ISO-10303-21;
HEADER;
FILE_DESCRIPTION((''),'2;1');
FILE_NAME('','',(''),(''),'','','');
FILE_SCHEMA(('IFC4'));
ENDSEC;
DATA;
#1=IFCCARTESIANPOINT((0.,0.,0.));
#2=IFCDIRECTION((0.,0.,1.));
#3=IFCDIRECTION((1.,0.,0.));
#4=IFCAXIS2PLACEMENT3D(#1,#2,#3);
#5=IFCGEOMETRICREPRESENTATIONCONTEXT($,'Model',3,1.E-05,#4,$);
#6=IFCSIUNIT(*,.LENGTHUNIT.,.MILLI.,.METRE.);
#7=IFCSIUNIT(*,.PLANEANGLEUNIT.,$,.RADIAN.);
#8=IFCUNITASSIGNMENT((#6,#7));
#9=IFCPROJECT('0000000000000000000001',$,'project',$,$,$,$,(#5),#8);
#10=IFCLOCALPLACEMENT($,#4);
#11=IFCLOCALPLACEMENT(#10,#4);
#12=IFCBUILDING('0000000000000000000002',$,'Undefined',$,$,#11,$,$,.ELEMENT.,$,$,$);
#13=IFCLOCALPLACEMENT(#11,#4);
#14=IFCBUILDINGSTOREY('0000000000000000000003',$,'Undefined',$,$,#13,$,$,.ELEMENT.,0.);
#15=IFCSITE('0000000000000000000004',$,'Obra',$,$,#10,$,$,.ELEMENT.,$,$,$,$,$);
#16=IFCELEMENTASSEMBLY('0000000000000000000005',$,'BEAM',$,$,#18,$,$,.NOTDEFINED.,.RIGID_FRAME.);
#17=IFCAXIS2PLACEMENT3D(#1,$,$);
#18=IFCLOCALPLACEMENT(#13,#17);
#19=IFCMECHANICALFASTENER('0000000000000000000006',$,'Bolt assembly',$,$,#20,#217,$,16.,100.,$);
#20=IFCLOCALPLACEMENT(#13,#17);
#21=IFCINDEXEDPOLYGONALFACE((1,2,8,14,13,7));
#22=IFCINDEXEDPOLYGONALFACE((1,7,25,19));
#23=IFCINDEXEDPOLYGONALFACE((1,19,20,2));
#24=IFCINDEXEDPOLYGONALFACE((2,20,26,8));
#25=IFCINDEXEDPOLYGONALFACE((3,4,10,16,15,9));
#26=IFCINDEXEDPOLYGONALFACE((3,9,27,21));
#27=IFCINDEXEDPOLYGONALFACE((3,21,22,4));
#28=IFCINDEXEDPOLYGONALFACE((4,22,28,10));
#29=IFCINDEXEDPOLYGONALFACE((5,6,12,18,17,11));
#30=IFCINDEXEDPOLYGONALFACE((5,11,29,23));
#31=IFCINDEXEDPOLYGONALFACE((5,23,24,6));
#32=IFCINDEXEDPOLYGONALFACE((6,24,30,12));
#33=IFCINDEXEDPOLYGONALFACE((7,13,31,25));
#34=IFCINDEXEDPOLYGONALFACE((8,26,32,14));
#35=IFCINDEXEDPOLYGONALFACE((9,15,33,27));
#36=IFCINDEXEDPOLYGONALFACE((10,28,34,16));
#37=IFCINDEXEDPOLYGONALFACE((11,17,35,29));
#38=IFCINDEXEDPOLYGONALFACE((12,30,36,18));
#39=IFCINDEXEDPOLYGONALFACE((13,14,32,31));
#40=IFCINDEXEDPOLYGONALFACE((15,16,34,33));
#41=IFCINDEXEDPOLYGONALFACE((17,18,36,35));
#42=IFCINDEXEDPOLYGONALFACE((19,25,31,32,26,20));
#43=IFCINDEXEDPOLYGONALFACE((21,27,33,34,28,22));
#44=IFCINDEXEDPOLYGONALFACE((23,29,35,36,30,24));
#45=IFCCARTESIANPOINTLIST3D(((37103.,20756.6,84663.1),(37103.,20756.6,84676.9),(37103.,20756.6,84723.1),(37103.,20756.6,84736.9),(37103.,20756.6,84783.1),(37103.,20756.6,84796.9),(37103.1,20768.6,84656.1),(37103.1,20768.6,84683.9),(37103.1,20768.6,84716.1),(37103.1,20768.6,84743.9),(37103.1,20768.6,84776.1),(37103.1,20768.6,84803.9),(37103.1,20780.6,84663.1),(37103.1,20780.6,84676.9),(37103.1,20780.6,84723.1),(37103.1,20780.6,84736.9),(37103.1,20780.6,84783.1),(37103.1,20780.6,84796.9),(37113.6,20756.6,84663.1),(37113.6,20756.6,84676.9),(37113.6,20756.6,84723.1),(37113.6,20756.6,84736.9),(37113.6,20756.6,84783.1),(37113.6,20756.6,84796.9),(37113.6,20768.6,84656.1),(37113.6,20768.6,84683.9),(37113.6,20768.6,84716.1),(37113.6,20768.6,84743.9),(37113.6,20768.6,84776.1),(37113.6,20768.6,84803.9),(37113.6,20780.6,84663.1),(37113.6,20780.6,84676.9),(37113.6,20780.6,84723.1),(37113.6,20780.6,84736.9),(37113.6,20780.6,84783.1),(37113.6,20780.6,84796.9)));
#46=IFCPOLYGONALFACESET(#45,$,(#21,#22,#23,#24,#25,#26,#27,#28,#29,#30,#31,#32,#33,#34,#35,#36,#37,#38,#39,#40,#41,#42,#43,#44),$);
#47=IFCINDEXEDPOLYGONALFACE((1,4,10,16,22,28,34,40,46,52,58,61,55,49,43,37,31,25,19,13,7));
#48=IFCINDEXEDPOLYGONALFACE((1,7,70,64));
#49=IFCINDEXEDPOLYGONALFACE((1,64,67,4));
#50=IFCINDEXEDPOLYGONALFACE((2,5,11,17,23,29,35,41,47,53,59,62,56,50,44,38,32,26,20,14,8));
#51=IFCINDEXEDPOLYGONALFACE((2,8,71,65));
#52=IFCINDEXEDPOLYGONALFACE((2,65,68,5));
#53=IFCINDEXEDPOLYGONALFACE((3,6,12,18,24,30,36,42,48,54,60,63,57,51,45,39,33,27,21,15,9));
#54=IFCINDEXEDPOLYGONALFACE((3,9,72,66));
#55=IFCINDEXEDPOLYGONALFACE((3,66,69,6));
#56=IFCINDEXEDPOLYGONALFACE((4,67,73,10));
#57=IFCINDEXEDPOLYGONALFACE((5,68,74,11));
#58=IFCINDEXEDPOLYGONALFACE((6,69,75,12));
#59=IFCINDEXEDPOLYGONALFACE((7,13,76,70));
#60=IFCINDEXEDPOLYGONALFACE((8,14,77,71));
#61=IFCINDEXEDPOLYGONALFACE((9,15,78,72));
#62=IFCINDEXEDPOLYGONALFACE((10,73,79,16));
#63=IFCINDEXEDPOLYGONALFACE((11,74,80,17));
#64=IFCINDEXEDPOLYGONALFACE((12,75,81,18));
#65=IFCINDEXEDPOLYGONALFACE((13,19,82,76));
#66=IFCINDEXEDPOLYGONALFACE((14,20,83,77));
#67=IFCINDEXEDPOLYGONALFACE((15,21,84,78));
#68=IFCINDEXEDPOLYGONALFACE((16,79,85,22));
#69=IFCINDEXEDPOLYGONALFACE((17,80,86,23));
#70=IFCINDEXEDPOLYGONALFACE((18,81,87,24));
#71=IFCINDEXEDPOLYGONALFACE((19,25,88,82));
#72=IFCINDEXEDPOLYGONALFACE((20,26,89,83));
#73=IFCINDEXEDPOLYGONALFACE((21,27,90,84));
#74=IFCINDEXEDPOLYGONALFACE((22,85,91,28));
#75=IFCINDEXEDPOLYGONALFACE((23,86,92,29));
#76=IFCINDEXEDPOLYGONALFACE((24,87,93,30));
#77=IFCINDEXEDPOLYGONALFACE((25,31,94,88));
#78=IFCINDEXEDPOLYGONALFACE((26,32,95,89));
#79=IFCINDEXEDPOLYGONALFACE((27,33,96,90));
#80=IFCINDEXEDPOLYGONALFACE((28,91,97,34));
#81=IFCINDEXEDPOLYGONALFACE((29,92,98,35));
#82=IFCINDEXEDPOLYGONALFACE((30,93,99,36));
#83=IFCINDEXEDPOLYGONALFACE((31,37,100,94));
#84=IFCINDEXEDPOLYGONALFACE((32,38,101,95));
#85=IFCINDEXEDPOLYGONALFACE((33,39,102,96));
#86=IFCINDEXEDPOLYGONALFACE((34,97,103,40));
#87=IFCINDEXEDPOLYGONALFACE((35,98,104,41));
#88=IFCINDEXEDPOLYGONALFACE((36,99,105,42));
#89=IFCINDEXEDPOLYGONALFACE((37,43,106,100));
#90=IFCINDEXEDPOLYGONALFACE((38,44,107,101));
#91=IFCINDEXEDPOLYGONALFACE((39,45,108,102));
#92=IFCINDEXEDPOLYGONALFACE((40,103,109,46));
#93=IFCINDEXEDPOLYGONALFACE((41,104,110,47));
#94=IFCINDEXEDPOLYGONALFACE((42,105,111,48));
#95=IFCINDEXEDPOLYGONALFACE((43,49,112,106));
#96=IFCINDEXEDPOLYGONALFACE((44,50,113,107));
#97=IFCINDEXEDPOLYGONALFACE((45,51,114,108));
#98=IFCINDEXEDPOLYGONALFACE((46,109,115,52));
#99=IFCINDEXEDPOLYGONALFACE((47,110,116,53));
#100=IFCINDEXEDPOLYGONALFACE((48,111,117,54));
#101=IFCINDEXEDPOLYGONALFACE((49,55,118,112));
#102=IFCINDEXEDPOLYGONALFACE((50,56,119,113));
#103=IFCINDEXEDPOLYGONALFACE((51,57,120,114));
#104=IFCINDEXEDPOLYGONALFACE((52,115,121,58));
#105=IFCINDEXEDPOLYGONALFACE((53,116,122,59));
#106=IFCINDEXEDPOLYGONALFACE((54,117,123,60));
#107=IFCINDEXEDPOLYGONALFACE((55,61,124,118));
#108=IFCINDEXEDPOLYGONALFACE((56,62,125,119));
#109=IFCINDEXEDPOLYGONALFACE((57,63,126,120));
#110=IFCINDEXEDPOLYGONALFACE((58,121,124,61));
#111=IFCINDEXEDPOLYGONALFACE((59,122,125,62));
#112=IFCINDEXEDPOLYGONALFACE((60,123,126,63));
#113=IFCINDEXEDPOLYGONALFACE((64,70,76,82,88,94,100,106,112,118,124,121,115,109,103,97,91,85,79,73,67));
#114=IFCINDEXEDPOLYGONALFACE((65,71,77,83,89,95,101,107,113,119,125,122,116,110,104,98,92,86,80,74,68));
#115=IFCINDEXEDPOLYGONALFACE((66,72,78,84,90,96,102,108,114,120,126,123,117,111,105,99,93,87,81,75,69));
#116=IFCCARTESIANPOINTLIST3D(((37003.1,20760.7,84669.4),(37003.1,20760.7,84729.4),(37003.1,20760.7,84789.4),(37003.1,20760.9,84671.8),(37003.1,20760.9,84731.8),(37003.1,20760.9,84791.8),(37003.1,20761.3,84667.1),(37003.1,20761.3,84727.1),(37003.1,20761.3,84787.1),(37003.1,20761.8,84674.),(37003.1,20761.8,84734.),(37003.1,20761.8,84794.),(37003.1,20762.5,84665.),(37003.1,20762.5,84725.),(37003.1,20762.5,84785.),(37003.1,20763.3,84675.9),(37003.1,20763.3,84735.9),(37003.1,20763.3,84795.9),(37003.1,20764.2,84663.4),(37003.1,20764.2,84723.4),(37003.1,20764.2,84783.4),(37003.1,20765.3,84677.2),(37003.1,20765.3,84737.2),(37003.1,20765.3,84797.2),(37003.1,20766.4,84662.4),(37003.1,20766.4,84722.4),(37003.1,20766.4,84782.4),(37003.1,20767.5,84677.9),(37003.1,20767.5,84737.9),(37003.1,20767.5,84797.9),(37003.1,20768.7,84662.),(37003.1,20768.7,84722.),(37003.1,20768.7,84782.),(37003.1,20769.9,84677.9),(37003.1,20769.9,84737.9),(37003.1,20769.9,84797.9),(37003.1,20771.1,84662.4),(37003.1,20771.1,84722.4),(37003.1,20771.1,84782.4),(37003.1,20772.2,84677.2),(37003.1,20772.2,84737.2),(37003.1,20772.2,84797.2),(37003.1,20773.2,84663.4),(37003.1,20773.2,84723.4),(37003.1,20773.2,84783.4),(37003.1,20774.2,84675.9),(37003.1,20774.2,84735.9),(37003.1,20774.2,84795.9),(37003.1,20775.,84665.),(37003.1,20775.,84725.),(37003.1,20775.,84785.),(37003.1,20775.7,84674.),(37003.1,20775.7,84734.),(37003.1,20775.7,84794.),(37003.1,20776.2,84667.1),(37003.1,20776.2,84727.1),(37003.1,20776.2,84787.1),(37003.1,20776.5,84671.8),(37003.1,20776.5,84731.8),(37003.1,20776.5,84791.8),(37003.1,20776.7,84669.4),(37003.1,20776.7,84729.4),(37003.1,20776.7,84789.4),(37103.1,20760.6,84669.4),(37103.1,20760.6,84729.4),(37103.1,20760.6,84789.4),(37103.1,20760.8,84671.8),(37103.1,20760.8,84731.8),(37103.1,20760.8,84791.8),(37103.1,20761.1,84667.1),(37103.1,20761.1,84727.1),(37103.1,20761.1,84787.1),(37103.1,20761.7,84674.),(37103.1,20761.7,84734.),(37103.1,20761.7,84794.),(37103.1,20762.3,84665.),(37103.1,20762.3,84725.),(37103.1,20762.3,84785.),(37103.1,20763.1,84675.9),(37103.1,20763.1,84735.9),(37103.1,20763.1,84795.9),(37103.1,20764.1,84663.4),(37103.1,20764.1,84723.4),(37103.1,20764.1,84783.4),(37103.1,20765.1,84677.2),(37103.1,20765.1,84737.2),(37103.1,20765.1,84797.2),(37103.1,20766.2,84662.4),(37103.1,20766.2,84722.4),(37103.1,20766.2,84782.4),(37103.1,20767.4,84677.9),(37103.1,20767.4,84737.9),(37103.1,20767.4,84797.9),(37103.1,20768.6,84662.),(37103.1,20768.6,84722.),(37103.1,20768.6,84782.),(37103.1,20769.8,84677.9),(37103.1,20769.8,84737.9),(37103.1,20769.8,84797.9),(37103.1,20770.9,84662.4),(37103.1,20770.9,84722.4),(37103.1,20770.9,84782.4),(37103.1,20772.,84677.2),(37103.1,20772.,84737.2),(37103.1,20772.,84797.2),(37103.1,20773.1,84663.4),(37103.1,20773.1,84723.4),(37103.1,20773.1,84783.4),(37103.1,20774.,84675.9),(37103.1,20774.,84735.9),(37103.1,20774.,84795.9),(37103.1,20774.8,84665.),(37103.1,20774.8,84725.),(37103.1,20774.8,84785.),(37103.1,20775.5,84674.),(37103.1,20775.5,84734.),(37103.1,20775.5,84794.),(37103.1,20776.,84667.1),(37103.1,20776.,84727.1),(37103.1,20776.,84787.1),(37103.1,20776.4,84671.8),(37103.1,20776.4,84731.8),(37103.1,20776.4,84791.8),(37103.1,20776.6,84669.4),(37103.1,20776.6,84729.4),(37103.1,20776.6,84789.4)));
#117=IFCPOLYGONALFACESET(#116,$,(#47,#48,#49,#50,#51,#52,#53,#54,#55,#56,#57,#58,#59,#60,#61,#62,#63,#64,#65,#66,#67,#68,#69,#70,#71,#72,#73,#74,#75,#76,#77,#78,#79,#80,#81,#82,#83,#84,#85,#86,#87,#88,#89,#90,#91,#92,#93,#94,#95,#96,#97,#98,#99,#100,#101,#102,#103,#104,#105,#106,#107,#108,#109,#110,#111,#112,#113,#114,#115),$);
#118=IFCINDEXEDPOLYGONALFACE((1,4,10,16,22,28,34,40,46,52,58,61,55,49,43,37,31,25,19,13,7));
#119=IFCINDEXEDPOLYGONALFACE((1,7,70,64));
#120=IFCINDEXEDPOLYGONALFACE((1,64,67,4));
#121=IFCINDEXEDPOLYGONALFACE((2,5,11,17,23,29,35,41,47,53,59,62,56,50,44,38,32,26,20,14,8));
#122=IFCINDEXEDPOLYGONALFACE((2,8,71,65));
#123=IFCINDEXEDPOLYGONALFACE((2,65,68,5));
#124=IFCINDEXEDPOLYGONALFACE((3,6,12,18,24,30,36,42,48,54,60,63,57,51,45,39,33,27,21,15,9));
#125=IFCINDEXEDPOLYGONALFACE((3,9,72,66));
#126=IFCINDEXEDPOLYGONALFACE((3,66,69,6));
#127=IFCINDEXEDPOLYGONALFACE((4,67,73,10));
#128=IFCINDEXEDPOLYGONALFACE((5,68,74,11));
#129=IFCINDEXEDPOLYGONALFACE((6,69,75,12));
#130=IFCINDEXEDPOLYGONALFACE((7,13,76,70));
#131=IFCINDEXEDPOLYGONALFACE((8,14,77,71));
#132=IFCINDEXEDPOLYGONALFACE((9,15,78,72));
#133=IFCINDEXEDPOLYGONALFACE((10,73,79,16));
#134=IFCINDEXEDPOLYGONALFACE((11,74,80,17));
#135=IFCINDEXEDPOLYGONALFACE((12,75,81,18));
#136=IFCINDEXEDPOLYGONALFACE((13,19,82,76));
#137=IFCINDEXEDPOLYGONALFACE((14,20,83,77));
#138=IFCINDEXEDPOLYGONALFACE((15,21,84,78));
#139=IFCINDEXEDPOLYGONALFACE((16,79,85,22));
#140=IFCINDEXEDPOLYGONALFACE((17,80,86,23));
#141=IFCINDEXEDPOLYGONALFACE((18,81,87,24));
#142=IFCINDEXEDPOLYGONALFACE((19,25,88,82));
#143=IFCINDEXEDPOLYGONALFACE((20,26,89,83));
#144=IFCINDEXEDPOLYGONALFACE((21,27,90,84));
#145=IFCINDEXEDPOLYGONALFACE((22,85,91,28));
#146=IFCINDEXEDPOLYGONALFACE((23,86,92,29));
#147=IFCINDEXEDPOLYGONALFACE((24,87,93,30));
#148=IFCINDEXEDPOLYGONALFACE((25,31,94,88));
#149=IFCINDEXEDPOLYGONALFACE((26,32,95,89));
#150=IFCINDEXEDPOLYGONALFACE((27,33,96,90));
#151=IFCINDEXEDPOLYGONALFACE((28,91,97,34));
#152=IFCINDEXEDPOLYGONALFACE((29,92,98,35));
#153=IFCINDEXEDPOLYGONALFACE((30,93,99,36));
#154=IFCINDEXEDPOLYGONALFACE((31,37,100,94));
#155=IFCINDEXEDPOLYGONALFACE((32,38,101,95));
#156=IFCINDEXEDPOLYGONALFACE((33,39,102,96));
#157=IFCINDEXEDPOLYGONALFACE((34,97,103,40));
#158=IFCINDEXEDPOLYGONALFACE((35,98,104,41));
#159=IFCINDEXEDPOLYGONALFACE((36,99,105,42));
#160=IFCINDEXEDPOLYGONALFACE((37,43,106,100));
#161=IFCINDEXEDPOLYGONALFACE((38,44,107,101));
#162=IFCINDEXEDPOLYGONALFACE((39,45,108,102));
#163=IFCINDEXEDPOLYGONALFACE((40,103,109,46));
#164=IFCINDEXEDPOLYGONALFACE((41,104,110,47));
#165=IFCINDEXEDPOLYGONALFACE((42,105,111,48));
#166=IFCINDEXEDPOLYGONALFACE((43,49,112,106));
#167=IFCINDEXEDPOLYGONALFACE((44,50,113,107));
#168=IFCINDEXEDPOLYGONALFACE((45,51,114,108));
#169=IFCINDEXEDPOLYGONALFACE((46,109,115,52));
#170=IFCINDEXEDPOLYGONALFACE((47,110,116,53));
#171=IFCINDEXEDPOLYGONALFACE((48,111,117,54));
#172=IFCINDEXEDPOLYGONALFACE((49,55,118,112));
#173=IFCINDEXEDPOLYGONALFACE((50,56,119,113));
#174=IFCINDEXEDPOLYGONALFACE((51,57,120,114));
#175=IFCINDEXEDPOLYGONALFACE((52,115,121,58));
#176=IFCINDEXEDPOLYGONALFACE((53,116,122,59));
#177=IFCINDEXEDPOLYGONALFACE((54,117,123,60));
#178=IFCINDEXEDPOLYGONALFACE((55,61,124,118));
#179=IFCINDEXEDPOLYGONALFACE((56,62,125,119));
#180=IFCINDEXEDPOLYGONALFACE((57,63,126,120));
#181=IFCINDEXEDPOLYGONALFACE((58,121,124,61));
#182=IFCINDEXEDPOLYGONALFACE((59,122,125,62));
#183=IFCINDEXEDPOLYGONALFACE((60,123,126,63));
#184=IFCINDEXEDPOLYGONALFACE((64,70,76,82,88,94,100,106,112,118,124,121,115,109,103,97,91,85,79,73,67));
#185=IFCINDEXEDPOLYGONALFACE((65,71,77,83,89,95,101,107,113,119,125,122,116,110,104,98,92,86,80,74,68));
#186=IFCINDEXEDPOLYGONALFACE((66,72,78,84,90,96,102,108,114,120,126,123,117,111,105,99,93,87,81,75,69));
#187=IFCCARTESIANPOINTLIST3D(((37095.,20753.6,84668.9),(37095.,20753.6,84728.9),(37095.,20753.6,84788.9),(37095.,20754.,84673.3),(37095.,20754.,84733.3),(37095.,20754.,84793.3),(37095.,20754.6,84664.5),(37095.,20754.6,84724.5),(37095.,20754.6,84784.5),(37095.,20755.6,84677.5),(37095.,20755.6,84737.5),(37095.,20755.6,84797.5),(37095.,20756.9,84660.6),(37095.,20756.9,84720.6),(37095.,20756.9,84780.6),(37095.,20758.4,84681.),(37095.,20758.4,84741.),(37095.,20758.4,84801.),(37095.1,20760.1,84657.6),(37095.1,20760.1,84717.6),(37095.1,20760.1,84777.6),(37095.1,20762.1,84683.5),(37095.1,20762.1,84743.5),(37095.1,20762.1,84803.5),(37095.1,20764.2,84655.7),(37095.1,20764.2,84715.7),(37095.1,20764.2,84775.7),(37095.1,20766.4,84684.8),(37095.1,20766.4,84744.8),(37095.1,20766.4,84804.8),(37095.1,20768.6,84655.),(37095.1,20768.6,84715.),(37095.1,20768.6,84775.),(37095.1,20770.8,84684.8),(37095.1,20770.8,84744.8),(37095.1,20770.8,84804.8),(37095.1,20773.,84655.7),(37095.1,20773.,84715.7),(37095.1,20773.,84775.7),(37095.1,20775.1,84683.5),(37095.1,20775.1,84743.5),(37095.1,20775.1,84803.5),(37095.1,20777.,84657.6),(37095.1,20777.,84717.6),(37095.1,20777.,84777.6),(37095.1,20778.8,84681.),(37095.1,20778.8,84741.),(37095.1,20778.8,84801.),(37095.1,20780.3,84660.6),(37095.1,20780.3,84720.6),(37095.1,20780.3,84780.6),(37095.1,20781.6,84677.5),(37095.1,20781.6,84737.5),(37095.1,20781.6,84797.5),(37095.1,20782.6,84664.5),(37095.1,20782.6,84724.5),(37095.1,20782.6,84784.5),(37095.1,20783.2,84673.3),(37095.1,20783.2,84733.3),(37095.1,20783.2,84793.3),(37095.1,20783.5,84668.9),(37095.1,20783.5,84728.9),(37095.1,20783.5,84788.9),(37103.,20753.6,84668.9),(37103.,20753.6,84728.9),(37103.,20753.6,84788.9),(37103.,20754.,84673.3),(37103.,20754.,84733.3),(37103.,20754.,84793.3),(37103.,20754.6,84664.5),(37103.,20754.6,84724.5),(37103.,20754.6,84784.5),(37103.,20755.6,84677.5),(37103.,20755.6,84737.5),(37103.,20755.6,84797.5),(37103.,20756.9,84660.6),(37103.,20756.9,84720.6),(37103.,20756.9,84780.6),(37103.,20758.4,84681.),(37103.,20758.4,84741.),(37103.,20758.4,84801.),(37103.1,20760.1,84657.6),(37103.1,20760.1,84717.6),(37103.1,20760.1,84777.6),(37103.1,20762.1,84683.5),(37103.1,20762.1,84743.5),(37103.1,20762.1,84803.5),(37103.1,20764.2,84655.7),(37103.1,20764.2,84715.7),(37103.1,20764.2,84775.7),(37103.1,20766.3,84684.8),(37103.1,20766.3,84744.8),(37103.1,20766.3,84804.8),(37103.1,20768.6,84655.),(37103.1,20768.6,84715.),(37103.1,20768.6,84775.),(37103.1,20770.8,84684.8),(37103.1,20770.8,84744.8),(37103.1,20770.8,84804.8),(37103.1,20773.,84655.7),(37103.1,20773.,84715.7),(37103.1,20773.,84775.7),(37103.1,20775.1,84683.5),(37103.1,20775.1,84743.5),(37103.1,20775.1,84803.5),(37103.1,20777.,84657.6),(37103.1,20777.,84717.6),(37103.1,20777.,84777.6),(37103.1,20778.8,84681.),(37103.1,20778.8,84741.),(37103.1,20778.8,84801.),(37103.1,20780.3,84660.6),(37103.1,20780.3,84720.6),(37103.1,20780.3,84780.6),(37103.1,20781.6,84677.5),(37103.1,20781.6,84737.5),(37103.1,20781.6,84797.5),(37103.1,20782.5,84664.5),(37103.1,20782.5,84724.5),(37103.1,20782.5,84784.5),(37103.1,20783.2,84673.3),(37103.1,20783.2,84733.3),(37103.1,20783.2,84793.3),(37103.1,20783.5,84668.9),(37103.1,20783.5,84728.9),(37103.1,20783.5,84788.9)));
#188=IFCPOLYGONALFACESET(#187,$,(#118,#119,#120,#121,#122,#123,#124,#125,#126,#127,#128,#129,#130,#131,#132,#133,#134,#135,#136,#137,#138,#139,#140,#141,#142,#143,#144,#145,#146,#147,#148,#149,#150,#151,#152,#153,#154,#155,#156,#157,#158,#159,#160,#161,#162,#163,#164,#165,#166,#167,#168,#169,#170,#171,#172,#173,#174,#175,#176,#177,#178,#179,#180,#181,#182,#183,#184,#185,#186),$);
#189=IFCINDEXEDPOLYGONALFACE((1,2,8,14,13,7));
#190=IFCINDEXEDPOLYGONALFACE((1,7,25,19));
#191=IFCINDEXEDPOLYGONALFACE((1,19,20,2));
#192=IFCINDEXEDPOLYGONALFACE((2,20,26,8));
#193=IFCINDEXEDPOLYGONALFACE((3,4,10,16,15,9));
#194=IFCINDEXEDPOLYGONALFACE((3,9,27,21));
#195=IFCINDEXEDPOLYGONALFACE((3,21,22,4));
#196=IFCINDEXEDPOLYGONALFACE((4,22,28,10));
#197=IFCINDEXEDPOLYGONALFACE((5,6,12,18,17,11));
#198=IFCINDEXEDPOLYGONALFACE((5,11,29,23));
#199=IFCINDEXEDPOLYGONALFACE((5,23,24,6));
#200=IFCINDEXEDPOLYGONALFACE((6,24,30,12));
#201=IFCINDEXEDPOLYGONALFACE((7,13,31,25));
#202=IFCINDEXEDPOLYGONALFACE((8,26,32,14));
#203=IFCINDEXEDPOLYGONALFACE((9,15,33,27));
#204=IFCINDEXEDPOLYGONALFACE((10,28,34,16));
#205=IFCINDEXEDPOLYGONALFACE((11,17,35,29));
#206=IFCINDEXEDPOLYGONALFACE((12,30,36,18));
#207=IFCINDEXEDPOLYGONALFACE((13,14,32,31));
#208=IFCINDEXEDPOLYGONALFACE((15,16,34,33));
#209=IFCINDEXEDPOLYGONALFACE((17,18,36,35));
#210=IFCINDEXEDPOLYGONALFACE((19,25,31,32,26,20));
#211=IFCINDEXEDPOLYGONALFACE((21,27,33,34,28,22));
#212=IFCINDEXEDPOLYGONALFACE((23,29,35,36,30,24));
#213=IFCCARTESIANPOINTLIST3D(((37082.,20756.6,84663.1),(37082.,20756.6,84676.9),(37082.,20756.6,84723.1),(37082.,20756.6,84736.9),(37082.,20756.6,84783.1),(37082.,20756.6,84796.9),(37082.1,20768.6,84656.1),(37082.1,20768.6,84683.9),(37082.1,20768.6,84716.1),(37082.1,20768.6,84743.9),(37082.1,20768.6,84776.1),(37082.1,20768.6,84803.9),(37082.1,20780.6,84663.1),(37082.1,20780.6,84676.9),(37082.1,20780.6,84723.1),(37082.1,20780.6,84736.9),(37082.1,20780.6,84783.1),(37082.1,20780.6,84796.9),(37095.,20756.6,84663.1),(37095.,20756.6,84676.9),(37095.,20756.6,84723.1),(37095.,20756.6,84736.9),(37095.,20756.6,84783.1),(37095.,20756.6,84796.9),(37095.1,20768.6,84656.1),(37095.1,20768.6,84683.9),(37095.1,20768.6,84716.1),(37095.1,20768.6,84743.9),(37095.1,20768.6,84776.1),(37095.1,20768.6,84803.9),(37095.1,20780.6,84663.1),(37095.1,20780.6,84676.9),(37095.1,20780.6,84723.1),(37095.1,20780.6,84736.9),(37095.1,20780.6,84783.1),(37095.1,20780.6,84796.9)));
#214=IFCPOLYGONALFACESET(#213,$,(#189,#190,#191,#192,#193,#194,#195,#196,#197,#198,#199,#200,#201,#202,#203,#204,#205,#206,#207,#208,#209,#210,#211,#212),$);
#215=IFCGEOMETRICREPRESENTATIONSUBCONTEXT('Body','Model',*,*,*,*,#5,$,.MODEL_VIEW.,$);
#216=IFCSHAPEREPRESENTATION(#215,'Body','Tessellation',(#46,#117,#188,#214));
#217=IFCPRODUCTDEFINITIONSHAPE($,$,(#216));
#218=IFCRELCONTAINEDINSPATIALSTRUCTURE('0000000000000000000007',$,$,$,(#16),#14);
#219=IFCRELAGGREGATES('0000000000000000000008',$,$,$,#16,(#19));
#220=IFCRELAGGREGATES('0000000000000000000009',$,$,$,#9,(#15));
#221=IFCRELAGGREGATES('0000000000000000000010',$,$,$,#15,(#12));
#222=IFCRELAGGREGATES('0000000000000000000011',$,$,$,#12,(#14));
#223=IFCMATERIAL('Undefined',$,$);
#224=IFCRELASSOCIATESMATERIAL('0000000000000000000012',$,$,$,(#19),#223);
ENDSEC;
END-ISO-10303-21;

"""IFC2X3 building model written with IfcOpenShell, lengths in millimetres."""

from ifc_helpers import new_model, si_unit, frame, origin_with_axes, origin_2d_with_axis, place, context, subcontext, project, spatial, polyline, circle, outline, extrude, source, transform, mapped, material, element, aggregate, save


model = new_model("IFC2X3")

# Units and contexts
model_context = context("Model", 3, precision=1e-05, world=origin_with_axes())
body_context = subcontext(model_context, "Body", "Model", "MODEL_VIEW")
ifc_project = project(units=[si_unit("LENGTHUNIT", "METRE", prefix="MILLI"), si_unit("PLANEANGLEUNIT", "RADIAN")], contexts=[model_context])

# Site, building, storey
site_placement = place(None, origin_with_axes())
site = spatial("IfcSite", under=ifc_project, at=site_placement, Name="Obra", CompositionType="ELEMENT")
building_placement = place(site_placement, origin_with_axes())
building = spatial("IfcBuilding", under=site, at=building_placement, Name="Undefined", CompositionType="ELEMENT")
storey_placement = place(building_placement, origin_with_axes())
storey = spatial("IfcBuildingStorey", under=building, at=storey_placement, Name="Undefined", CompositionType="ELEMENT", Elevation=0.0)

# Shared definitions
ifc_material_1 = material(Name="Undefined")

# Element assembly, mechanical fastener
assembly_1_placement = place(storey_placement, origin_with_axes())
assembly_1 = element("IfcElementAssembly", 1, at=assembly_1_placement, inside=storey, Name="BEAM", AssemblyPlace="NOTDEFINED", PredefinedType="RIGID_FRAME")
shared_shape_1 = source(origin_with_axes(), body_context, "Body", "SweptSolid", [
    extrude(outline(polyline([(13.9, 0.0), (6.9, 12.0), (-6.9, 12.0), (-13.9, 0.0), (-6.9, -12.0), (6.9, -12.0), (13.9, 0.0)])), frame((0.0, -10.6, 0.0), z_axis=(0.0, 1.0, 0.0), x_axis=(1.0, 0.0, 0.0)), (0.0, 0.0, 1.0), 10.6),
    extrude(circle(Radius=8.0, at=origin_2d_with_axis()), frame((0.0, 0.0, 0.0), z_axis=(0.0, 1.0, 0.0), x_axis=(1.0, 0.0, 0.0)), (0.0, 0.0, 1.0), 100.0),
    extrude(circle(Radius=15.0, at=origin_2d_with_axis()), frame((0.0, 0.0, 0.0), z_axis=(0.0, 1.0, 0.0), x_axis=(1.0, 0.0, 0.0)), (0.0, 0.0, 1.0), 8.0),
    extrude(outline(polyline([(13.9, 0.0), (6.9, 12.0), (-6.9, 12.0), (-13.9, 0.0), (-6.9, -12.0), (6.9, -12.0), (13.9, 0.0)])), frame((0.0, 8.0, 0.0), z_axis=(0.0, 1.0, 0.0), x_axis=(1.0, 0.0, 0.0)), (0.0, 0.0, 1.0), 13.0),
])
mechanical_fastener_1_placement = place(assembly_1_placement, frame((37103.0, 20718.6, 84850.0), z_axis=(0.001435, 0.999999, 0.0), x_axis=(0.0, 0.0, -1.0)))
mechanical_fastener_1 = element("IfcMechanicalFastener", 2, at=mechanical_fastener_1_placement, material=ifc_material_1, Name="Bolt assembly", NominalDiameter=16.0, NominalLength=100.0, context=body_context, shape_type="MappedRepresentation", body=[
    mapped(shared_shape_1, transform((60.0, 0.0, 50.0))),
    mapped(shared_shape_1, transform((120.0, 0.0, 50.0))),
    mapped(shared_shape_1, transform((180.0, 0.0, 50.0))),
])
aggregate(assembly_1, [mechanical_fastener_1])

save(model, "model.ifc")
